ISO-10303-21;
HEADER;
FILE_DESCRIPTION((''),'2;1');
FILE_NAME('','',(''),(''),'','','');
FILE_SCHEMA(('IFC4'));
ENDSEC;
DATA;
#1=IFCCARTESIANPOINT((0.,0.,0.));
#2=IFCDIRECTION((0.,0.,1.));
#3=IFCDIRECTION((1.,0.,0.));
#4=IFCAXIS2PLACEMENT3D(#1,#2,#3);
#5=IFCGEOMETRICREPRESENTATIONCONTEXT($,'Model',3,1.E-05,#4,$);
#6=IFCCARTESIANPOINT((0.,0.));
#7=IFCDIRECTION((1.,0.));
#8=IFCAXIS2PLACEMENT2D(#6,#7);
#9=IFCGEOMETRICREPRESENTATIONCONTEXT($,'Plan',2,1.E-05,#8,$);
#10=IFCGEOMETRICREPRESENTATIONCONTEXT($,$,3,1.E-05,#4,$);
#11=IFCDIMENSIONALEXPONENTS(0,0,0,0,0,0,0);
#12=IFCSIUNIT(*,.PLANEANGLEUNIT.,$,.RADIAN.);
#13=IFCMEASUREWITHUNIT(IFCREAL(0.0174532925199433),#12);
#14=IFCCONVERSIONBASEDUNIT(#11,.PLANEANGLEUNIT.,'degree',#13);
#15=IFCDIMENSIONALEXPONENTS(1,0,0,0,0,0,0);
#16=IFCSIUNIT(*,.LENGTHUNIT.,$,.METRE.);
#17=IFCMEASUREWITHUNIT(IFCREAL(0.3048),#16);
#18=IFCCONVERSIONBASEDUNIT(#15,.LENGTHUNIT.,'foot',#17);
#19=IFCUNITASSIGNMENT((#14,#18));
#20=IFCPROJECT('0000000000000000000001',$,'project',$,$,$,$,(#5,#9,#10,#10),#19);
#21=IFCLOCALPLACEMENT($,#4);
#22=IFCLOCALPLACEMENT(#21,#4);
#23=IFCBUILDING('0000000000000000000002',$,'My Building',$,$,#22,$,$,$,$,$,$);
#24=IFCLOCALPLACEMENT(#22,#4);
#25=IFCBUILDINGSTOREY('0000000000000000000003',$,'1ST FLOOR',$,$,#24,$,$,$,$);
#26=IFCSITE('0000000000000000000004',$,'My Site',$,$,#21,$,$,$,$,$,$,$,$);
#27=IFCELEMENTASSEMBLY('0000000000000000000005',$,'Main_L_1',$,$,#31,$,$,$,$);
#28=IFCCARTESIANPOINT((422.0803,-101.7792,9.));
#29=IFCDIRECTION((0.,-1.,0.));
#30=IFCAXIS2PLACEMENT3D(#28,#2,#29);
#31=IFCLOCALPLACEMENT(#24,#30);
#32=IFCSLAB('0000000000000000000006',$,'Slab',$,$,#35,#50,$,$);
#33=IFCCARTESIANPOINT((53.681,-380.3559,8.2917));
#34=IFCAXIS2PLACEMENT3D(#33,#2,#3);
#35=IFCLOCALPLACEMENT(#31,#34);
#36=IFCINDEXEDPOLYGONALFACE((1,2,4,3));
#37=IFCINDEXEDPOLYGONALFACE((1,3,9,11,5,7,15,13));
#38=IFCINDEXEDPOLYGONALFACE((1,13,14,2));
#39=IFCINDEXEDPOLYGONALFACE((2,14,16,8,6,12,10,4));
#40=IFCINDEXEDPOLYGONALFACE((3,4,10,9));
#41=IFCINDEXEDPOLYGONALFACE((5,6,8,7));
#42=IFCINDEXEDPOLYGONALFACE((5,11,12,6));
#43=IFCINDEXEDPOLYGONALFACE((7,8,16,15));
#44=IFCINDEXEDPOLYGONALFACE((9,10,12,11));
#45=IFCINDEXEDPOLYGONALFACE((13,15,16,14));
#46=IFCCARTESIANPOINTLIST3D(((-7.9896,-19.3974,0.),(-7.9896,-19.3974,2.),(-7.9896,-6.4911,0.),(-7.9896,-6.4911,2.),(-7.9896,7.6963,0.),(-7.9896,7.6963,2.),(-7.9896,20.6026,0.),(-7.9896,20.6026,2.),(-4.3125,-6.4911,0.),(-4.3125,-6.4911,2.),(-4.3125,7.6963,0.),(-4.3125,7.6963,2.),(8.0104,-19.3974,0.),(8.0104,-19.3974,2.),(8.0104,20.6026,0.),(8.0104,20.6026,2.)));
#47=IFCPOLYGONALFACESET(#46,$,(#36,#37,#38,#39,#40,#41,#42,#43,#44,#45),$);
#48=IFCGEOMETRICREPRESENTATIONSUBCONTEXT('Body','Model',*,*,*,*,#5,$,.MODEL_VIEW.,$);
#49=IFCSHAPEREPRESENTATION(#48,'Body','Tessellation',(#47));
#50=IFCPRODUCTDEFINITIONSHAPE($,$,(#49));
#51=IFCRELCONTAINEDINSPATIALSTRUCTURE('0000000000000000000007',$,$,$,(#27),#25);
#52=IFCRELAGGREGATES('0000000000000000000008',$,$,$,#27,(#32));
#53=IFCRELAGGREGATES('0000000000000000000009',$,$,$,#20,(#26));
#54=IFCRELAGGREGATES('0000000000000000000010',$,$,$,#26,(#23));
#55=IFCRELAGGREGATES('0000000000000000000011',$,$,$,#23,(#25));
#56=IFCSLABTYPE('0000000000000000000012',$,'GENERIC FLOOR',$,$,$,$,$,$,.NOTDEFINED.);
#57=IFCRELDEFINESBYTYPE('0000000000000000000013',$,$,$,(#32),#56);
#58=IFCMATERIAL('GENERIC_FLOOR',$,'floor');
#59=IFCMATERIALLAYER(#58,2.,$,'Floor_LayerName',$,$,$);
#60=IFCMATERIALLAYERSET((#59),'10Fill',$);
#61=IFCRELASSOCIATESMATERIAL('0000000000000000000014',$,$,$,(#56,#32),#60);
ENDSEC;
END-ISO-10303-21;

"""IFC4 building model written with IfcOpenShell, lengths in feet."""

from ifc_helpers import new_model, entity, si_unit, converted_unit, frame, origin_with_axes, origin_2d_with_axis, place, context, subcontext, project, spatial, line, indexed_curve, outline, extrude, material, layer, layer_set, layer_usage, type_object, element, aggregate, save


model = new_model("IFC4")

# Units and contexts
model_context = context("Model", 3, precision=1e-05, world=origin_with_axes())
plan_context = context("Plan", 2, precision=1e-05, world=origin_2d_with_axis())
context_of_model = context(None, 3, precision=1e-05, world=origin_with_axes())
body_context = subcontext(model_context, "Body", "Model", "MODEL_VIEW")
ifc_project = project(units=[converted_unit("PLANEANGLEUNIT", "degree", entity("IfcReal", 0.0174532925199433), si_unit("PLANEANGLEUNIT", "RADIAN"), dimensions=[0, 0, 0, 0, 0, 0, 0]), converted_unit("LENGTHUNIT", "foot", entity("IfcReal", 0.3048), si_unit("LENGTHUNIT", "METRE"), dimensions=[1, 0, 0, 0, 0, 0, 0])], contexts=[model_context, plan_context, context_of_model, context_of_model])

# Site, building, storey
site_placement = place(None, origin_with_axes())
site = spatial("IfcSite", under=ifc_project, at=site_placement, Name="My Site")
building_placement = place(site_placement, origin_with_axes())
building = spatial("IfcBuilding", under=site, at=building_placement, Name="My Building")
storey_placement = place(building_placement, origin_with_axes())
storey = spatial("IfcBuildingStorey", under=building, at=storey_placement, Name="1ST FLOOR")

# Element assembly, slab
assembly_placement = place(storey_placement, frame((422.0803, -101.7792, 9.0), z_axis=(0.0, 0.0, 1.0), x_axis=(0.0, -1.0, 0.0)))
assembly = element("IfcElementAssembly", 1, at=assembly_placement, inside=storey, Name="Main_L_1")
ifc_material_1 = material(Name="GENERIC_FLOOR", Category="floor")
ifc_layer_1 = layer(ifc_material_1, 2.0, Name="Floor_LayerName")
ifc_layer_set_1 = layer_set([ifc_layer_1], Name="10Fill")
ifc_layer_usage_1 = layer_usage(ifc_layer_set_1, "AXIS3", "POSITIVE", 0.0)
slab_type_1 = type_object("IfcSlabType", Name="GENERIC FLOOR", PredefinedType="NOTDEFINED", material=ifc_layer_set_1)
slab_1_placement = place(assembly_placement, frame((53.681, -380.3559, 8.2917), z_axis=(0.0, 0.0, 1.0), x_axis=(1.0, 0.0, 0.0)))
slab_1 = element("IfcSlab", 2, at=slab_1_placement, type_object=slab_type_1, material=ifc_layer_usage_1, Name="Slab", context=body_context, shape_type="SweptSolid", body=[
    extrude(outline(indexed_curve([(-4.3125, 7.6963), (-7.9896, 7.6963), (-7.9896, 20.6026), (8.0104, 20.6026), (8.0104, -19.3974), (-7.9896, -19.3974), (-7.9896, -6.4911), (-4.3125, -6.4911)], segments=[line(8, 7), line(7, 6), line(6, 5), line(5, 4), line(4, 3), line(3, 2), line(2, 1), line(1, 8)], self_intersect=False)), None, (0.0, 0.0, 1.0), 2.0),
])
aggregate(assembly, [slab_1])

save(model, "model.ifc")
